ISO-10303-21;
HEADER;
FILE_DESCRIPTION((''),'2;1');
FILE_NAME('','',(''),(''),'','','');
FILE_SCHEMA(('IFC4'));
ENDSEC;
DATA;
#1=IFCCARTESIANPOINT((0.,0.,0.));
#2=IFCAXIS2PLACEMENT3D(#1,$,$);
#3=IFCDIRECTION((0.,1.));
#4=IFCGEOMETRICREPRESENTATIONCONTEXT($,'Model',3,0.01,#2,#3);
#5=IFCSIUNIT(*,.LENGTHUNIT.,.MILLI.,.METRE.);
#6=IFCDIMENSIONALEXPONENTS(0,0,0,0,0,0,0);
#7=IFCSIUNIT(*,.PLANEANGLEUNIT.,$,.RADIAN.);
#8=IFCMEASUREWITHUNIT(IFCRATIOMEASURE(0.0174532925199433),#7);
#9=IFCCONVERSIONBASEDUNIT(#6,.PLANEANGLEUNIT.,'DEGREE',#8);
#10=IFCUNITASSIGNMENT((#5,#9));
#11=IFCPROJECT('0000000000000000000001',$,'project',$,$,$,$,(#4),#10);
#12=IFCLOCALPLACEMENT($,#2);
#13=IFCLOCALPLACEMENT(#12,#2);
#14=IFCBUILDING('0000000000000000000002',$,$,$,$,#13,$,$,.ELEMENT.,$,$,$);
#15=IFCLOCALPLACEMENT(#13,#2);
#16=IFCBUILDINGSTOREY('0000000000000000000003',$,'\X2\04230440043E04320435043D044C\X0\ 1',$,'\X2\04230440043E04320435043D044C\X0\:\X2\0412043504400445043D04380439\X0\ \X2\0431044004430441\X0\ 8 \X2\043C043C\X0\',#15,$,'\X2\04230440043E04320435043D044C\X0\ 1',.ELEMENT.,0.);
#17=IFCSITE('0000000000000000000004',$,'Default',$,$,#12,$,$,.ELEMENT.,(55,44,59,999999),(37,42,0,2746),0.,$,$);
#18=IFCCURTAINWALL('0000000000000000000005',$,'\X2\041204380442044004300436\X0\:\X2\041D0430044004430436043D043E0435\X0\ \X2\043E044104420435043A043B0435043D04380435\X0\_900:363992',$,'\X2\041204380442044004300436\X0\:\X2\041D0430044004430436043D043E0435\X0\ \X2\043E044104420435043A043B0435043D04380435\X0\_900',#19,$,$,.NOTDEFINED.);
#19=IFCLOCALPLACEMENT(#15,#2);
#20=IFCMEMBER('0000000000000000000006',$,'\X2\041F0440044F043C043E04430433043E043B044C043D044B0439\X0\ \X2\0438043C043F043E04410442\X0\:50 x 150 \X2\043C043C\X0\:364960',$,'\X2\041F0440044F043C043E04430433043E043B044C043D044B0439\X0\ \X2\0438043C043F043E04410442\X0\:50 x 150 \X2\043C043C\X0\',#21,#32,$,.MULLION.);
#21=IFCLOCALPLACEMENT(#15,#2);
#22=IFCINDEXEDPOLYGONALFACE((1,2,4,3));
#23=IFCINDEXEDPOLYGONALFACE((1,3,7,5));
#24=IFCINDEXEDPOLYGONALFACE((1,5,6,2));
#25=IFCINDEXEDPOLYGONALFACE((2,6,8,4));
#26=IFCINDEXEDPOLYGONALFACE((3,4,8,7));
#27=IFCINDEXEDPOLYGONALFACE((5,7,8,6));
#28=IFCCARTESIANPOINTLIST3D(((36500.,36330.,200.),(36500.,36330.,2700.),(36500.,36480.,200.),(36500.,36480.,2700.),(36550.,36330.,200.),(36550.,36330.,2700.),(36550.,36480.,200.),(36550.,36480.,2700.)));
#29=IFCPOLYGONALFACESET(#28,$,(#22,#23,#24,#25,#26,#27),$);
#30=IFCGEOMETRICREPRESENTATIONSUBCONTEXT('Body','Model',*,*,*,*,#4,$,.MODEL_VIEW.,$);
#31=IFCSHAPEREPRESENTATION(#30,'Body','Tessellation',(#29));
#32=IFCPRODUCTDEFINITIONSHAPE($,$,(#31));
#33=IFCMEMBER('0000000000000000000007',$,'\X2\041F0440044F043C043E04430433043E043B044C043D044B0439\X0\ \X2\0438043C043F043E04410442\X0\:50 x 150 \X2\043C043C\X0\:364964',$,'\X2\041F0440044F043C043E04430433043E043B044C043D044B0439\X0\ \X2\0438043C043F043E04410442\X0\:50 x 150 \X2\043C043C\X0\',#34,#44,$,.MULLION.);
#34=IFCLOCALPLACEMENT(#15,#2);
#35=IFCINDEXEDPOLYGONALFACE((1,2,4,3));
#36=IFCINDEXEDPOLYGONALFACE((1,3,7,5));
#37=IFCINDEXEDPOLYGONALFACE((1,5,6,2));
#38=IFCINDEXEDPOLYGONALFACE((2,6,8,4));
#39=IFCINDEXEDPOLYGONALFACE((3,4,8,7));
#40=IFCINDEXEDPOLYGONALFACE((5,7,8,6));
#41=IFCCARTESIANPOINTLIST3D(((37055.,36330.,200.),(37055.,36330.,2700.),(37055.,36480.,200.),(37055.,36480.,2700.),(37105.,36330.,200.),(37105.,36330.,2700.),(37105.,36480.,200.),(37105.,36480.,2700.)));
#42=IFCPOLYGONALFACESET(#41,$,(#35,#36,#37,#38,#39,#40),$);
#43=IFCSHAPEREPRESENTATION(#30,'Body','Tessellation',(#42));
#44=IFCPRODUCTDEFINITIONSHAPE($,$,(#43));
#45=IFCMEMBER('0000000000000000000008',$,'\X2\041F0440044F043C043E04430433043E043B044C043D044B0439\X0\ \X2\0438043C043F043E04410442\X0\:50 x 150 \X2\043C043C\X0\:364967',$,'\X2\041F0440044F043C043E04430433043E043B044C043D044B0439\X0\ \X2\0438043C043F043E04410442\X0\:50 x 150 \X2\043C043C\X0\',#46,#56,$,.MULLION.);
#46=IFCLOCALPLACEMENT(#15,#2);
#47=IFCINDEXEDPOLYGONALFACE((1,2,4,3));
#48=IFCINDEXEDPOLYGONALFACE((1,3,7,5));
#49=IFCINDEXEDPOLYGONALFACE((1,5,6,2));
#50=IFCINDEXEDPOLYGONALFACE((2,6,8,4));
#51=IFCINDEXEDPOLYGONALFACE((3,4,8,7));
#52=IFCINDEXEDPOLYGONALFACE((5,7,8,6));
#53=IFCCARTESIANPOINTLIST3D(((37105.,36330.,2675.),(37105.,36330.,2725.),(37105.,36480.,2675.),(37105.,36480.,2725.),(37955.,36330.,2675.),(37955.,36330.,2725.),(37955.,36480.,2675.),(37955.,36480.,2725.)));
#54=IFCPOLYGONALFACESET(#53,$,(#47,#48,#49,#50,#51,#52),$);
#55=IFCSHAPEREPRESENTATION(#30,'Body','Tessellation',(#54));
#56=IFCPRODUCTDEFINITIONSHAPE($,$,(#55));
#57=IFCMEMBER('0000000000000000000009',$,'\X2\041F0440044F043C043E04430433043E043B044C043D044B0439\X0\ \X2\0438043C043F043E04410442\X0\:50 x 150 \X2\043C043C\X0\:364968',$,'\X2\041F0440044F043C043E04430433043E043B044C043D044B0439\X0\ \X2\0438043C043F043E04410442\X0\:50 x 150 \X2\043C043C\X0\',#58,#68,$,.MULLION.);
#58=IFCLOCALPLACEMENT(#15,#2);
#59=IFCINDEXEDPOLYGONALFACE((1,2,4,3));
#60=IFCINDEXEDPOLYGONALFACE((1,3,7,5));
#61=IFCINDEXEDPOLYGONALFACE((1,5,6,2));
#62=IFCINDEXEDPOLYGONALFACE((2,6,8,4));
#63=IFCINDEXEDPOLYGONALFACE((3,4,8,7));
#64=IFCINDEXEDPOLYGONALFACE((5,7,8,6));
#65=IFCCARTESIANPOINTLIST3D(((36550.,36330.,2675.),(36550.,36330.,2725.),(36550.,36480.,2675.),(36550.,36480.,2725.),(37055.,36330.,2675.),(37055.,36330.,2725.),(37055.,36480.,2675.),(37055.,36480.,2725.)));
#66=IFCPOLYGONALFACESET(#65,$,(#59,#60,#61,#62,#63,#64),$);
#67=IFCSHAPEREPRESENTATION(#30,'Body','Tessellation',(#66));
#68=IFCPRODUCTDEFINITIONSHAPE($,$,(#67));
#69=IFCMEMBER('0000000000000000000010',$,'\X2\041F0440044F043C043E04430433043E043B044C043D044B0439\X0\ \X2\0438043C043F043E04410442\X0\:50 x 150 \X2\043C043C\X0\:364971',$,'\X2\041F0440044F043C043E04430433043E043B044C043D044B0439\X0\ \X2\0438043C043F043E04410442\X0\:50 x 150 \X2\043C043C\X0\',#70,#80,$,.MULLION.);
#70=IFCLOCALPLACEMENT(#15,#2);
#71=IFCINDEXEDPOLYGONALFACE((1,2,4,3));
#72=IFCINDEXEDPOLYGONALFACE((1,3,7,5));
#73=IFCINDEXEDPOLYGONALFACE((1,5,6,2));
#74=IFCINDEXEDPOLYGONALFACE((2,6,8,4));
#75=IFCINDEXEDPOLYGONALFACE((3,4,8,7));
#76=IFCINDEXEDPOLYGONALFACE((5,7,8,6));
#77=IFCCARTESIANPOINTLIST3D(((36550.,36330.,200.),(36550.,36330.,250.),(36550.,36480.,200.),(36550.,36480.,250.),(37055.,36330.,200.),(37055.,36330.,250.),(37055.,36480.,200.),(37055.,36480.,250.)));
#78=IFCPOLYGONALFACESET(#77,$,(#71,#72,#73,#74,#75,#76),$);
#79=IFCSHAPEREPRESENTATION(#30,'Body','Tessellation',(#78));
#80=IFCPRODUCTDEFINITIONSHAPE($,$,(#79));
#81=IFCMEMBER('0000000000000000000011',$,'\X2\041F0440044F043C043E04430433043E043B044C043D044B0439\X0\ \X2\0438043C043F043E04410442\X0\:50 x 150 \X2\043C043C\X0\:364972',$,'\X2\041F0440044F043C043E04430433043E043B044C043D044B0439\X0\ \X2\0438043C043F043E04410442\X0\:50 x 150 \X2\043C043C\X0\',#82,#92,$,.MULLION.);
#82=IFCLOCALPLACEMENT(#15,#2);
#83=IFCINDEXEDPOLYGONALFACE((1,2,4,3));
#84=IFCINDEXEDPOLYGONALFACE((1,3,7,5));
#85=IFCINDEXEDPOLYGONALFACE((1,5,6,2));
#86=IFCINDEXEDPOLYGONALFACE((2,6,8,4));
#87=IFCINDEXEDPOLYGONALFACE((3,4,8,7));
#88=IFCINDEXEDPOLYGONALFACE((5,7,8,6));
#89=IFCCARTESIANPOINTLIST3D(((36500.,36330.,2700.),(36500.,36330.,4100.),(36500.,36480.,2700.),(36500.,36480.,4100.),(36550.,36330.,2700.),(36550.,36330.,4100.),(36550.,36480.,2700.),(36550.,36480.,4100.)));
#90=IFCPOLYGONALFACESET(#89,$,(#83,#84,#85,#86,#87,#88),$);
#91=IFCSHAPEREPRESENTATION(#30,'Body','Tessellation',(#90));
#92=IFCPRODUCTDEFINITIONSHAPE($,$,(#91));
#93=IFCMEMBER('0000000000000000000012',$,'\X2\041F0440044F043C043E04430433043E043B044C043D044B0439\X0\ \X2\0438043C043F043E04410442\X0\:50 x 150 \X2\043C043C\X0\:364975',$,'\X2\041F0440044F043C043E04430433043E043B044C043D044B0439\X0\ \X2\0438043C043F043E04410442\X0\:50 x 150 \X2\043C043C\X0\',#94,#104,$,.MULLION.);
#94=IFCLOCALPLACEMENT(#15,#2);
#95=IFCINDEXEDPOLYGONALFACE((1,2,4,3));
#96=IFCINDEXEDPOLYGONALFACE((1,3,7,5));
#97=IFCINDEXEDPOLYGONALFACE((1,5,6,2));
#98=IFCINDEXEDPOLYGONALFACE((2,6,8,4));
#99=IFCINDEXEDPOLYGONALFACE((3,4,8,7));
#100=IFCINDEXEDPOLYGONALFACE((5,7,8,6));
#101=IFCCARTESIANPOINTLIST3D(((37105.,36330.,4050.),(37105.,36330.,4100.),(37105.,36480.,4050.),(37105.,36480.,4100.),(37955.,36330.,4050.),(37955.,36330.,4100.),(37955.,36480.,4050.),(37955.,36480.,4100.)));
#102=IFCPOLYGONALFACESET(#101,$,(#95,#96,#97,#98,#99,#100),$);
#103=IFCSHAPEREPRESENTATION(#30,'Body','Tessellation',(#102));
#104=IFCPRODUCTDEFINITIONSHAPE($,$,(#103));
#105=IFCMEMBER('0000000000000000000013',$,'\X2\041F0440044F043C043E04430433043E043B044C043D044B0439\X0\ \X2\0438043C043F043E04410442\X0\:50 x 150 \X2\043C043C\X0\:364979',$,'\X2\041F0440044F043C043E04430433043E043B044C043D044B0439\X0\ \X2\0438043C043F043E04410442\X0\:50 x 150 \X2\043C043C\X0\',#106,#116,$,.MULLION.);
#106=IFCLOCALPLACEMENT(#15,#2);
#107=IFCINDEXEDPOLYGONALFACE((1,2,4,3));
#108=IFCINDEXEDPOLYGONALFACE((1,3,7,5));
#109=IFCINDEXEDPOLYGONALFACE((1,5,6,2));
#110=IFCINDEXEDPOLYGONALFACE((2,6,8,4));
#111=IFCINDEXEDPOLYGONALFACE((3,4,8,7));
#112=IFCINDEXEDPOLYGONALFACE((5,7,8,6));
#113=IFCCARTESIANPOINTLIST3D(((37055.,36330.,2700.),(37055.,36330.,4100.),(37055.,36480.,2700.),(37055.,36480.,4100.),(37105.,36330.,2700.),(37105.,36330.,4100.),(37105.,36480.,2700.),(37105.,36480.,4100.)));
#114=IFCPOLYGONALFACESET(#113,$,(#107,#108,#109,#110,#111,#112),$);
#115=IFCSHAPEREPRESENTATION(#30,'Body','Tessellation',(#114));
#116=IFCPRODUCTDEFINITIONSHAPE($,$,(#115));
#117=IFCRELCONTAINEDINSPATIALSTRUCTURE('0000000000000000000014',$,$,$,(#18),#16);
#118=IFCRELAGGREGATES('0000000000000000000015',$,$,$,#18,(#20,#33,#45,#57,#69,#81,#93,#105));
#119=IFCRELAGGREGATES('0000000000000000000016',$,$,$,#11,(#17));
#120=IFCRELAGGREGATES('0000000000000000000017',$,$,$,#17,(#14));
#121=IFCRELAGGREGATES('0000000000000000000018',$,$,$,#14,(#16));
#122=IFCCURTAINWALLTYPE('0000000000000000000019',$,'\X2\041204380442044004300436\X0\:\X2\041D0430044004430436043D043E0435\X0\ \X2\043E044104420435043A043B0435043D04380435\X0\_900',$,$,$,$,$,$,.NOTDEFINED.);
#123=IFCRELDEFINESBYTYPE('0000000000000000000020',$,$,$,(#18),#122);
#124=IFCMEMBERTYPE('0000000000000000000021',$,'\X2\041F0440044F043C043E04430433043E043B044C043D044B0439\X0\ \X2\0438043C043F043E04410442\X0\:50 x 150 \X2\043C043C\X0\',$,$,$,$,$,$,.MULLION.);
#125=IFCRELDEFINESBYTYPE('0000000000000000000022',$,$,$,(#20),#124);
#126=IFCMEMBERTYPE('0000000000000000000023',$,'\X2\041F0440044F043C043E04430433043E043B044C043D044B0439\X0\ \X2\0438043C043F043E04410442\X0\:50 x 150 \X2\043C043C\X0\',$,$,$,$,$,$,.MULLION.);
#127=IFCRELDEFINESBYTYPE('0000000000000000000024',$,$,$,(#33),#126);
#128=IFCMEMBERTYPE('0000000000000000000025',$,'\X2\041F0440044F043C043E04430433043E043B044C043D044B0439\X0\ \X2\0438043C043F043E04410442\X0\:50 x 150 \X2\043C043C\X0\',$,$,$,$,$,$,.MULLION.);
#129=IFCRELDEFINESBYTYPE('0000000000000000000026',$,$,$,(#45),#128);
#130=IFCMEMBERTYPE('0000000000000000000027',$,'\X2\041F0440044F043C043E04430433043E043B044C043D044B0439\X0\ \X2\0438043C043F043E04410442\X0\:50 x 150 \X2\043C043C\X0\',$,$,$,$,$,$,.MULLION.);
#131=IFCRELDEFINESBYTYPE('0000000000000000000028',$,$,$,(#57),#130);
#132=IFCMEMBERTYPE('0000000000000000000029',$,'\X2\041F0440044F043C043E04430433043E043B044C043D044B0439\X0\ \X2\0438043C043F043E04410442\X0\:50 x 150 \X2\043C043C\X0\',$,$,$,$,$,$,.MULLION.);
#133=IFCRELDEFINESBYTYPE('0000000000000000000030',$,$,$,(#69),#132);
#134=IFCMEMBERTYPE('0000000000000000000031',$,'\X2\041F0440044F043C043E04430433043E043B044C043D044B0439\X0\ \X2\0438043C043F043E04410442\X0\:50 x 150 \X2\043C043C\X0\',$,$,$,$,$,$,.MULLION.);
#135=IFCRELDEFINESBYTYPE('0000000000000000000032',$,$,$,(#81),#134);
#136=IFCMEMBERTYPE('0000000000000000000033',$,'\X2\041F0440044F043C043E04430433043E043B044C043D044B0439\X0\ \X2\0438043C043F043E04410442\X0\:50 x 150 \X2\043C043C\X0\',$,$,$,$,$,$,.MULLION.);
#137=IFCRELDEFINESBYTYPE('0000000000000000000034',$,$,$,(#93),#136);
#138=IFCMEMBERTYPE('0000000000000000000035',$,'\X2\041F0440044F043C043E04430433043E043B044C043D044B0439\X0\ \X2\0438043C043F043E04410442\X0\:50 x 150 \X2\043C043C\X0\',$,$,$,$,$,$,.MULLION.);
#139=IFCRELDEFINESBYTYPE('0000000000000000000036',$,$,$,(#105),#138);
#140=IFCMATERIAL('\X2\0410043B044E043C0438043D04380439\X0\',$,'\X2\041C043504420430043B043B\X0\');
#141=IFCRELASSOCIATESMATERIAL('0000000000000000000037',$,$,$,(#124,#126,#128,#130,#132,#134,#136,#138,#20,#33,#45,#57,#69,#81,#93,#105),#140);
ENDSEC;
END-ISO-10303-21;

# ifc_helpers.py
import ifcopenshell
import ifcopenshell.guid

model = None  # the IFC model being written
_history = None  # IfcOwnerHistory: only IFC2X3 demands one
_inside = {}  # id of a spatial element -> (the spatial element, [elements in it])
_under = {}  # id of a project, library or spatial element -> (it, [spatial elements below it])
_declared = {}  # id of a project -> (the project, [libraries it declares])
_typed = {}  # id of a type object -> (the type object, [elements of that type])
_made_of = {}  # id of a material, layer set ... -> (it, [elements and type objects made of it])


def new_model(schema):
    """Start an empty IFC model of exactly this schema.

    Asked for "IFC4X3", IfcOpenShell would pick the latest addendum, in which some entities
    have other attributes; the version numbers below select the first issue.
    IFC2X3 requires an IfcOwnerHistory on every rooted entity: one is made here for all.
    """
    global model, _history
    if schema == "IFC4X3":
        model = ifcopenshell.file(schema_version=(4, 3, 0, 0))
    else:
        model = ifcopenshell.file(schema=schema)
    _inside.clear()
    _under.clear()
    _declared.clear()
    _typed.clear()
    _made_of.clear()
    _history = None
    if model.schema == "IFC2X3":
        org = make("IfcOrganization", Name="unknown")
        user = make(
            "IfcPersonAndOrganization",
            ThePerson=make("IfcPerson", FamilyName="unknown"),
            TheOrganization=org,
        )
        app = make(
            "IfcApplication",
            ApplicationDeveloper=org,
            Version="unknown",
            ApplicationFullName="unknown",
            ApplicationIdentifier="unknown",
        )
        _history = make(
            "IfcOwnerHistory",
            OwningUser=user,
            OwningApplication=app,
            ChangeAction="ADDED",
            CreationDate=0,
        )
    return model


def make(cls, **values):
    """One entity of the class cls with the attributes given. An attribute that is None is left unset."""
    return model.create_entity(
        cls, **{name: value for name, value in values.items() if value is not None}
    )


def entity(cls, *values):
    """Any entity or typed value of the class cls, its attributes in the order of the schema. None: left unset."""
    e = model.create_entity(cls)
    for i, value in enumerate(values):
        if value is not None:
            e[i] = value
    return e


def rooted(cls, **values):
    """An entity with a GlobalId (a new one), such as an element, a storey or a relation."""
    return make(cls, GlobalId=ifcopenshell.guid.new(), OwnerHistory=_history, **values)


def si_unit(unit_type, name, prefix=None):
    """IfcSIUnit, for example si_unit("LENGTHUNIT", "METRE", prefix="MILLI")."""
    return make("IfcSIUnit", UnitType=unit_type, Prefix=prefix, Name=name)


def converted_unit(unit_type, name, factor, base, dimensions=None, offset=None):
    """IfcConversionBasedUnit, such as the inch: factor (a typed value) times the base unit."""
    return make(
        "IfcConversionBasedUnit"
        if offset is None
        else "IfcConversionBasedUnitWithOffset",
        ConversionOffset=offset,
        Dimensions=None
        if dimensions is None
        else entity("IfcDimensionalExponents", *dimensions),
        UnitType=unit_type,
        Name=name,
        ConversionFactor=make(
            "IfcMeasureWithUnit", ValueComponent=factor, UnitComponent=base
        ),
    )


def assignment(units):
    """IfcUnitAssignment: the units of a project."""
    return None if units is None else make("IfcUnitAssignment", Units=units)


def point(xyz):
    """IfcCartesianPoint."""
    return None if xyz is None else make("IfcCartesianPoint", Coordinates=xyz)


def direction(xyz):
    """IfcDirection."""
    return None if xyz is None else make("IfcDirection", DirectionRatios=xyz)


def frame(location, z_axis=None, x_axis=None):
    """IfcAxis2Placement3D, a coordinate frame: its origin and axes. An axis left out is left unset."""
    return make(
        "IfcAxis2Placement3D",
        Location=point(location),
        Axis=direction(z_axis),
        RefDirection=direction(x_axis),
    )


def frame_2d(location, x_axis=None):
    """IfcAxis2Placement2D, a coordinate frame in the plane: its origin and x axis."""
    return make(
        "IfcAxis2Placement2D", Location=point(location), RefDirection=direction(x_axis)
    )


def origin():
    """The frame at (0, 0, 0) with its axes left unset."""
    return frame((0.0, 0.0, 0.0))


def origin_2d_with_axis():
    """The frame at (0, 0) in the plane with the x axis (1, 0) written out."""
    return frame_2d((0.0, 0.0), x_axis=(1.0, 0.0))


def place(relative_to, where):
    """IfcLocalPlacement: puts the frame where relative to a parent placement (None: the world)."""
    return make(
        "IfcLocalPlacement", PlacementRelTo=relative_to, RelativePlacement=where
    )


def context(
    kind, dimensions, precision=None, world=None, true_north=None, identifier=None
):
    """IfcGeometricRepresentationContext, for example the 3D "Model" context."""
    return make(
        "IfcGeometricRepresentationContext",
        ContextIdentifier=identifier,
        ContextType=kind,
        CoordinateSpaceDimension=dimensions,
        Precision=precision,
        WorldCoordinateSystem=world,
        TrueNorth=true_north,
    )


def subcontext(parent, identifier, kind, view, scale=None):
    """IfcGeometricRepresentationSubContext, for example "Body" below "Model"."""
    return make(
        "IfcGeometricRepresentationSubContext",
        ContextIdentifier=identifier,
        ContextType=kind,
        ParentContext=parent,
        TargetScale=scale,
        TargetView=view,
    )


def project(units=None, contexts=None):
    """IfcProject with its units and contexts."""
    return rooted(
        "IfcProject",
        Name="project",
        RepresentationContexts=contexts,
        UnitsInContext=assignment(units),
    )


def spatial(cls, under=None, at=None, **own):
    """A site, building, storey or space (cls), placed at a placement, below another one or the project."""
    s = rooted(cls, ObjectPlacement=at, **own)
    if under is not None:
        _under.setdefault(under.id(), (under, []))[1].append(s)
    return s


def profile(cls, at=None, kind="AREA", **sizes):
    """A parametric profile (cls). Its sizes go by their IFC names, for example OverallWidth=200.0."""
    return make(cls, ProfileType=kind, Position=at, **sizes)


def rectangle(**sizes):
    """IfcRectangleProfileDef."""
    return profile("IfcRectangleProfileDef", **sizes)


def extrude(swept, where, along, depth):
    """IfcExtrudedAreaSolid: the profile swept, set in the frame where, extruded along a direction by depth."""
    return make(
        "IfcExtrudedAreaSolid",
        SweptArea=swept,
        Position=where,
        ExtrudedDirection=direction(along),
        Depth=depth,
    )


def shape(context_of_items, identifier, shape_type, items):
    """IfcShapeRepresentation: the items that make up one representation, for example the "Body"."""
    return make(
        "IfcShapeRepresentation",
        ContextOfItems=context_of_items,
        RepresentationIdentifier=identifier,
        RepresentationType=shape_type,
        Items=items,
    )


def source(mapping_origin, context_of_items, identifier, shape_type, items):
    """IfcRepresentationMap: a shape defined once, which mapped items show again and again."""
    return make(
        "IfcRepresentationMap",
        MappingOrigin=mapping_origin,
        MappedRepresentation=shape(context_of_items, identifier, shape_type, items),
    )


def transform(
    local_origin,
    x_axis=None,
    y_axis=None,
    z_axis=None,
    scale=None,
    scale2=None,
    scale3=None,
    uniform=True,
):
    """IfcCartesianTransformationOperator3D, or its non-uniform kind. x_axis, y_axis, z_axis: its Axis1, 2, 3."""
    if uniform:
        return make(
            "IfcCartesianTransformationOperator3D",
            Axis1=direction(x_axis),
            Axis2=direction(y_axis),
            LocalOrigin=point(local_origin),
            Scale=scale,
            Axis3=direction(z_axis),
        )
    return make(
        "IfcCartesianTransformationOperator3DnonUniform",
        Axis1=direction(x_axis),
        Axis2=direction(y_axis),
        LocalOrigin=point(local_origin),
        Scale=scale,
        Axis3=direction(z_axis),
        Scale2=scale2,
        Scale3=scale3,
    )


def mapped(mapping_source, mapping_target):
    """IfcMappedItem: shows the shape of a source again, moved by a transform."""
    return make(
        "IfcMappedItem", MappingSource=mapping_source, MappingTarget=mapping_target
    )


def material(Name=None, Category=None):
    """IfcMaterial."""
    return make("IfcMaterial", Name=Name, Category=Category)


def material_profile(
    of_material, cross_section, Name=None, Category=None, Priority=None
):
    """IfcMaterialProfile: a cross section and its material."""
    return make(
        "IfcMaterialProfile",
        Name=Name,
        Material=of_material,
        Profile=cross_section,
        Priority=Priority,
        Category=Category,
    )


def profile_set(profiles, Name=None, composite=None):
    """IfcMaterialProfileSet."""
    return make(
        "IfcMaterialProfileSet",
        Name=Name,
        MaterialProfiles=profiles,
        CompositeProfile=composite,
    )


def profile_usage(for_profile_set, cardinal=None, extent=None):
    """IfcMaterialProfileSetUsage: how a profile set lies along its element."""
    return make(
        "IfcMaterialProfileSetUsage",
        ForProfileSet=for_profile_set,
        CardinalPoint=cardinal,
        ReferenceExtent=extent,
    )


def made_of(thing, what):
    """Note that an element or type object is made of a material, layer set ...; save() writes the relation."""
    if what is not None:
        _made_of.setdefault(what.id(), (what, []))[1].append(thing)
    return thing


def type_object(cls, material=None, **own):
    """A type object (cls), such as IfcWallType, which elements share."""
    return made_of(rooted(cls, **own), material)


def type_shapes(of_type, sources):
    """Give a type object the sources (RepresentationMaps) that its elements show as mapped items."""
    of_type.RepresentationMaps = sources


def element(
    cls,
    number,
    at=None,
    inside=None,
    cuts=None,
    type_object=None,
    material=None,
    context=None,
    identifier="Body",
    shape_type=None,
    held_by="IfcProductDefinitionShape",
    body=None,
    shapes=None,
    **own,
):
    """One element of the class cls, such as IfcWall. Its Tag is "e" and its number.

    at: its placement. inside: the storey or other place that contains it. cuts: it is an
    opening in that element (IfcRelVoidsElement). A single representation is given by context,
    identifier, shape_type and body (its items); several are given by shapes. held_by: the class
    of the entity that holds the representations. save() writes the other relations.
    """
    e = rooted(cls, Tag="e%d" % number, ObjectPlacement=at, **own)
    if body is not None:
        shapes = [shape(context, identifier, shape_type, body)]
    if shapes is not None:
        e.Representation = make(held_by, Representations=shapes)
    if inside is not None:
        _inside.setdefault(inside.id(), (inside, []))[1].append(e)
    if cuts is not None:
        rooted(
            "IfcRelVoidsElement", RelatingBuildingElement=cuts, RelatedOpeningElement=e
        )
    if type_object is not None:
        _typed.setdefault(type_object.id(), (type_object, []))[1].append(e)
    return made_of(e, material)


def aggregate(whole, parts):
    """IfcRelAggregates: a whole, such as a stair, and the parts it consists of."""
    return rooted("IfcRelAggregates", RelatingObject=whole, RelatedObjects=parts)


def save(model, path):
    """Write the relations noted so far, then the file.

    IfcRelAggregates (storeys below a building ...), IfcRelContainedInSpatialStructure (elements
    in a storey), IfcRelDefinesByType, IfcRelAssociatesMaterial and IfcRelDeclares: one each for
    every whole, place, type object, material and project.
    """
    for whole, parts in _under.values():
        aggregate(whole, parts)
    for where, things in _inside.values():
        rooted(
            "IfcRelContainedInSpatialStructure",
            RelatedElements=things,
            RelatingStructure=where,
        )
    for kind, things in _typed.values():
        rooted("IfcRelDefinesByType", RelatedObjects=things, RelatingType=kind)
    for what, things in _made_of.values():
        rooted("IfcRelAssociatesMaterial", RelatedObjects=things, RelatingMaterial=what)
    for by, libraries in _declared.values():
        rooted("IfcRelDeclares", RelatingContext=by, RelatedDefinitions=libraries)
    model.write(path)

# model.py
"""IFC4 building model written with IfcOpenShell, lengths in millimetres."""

from ifc_helpers import new_model, entity, si_unit, converted_unit, direction, frame, origin, origin_2d_with_axis, place, context, subcontext, project, spatial, rectangle, extrude, source, transform, mapped, material, material_profile, profile_set, profile_usage, type_object, type_shapes, element, aggregate, save


model = new_model("IFC4")

# Units and contexts
model_context = context("Model", 3, precision=0.01, world=origin(), true_north=direction((0.0, 1.0)))
body_context = subcontext(model_context, "Body", "Model", "MODEL_VIEW")
ifc_project = project(units=[si_unit("LENGTHUNIT", "METRE", prefix="MILLI"), converted_unit("PLANEANGLEUNIT", "DEGREE", entity("IfcRatioMeasure", 0.0174532925199433), si_unit("PLANEANGLEUNIT", "RADIAN"), dimensions=[0, 0, 0, 0, 0, 0, 0])], contexts=[model_context])

# Site, building, storey
site_placement = place(None, origin())
site = spatial("IfcSite", under=ifc_project, at=site_placement, Name="Default", CompositionType="ELEMENT", RefLatitude=(55, 44, 59, 999999), RefLongitude=(37, 42, 0, 2746), RefElevation=0.0)
building_placement = place(site_placement, origin())
building = spatial("IfcBuilding", under=site, at=building_placement, CompositionType="ELEMENT")
storey_placement = place(building_placement, origin())
storey = spatial("IfcBuildingStorey", under=building, at=storey_placement, Name="Уровень 1", ObjectType="Уровень:Верхний брус 8 мм", LongName="Уровень 1", CompositionType="ELEMENT", Elevation=0.0)

# Curtain wall, members
ifc_material_1 = material(Name="Алюминий", Category="Металл")
ifc_material_profile = material_profile(ifc_material_1, rectangle(XDim=150.0, YDim=50.0, at=origin_2d_with_axis()), Name="50 x 150 мм")
ifc_profile_set = profile_set([ifc_material_profile], Name="50 x 150 мм")
curtain_wall_type_1 = type_object("IfcCurtainWallType", Name="Витраж:Наружное остекление_900", PredefinedType="NOTDEFINED")
curtain_wall_1_placement = place(storey_placement, origin())
curtain_wall_1 = element("IfcCurtainWall", 1, at=curtain_wall_1_placement, inside=storey, type_object=curtain_wall_type_1, Name="Витраж:Наружное остекление_900:363992", ObjectType="Витраж:Наружное остекление_900", PredefinedType="NOTDEFINED")
ifc_profile_usage_1 = profile_usage(ifc_profile_set)
member_type_1 = type_object("IfcMemberType", Name="Прямоугольный импост:50 x 150 мм", PredefinedType="MULLION", material=ifc_profile_set)
shared_shape_1 = source(origin(), body_context, "Body", "SweptSolid", [
    extrude(rectangle(XDim=150.0, YDim=50.0, at=origin_2d_with_axis()), frame((-25.0, 0.0, -2500.0), z_axis=(0.0, 0.0, 1.0), x_axis=(0.0, -1.0, 0.0)), (0.0, 0.0, 1.0), 2500.0),
])
type_shapes(member_type_1, [shared_shape_1])
member_1_placement = place(storey_placement, frame((36500.0, 36405.0, 200.0), z_axis=(0.0, 0.0, -1.0), x_axis=(-1.0, 0.0, 0.0)))
member_1 = element("IfcMember", 2, at=member_1_placement, type_object=member_type_1, material=ifc_profile_usage_1, Name="Прямоугольный импост:50 x 150 мм:364960", ObjectType="Прямоугольный импост:50 x 150 мм", PredefinedType="MULLION", context=body_context, shape_type="MappedRepresentation", body=[
    mapped(shared_shape_1, transform((0.0, 0.0, 0.0), scale=1.0)),
])
ifc_profile_usage_2 = profile_usage(ifc_profile_set)
member_type_2 = type_object("IfcMemberType", Name="Прямоугольный импост:50 x 150 мм", PredefinedType="MULLION", material=ifc_profile_set)
shared_shape_2 = source(origin(), body_context, "Body", "SweptSolid", [
    extrude(rectangle(XDim=150.0, YDim=50.0, at=origin_2d_with_axis()), frame((0.0, 0.0, -2500.0), z_axis=(0.0, 0.0, 1.0), x_axis=(0.0, -1.0, 0.0)), (0.0, 0.0, 1.0), 2500.0),
])
type_shapes(member_type_2, [shared_shape_2])
member_2_placement = place(storey_placement, frame((37080.0, 36405.0, 200.0), z_axis=(0.0, 0.0, -1.0), x_axis=(-1.0, 0.0, 0.0)))
member_2 = element("IfcMember", 3, at=member_2_placement, type_object=member_type_2, material=ifc_profile_usage_2, Name="Прямоугольный импост:50 x 150 мм:364964", ObjectType="Прямоугольный импост:50 x 150 мм", PredefinedType="MULLION", context=body_context, shape_type="MappedRepresentation", body=[
    mapped(shared_shape_2, transform((0.0, 0.0, 0.0), scale=1.0)),
])
ifc_profile_usage_3 = profile_usage(ifc_profile_set)
member_type_3 = type_object("IfcMemberType", Name="Прямоугольный импост:50 x 150 мм", PredefinedType="MULLION", material=ifc_profile_set)
shared_shape_3 = source(origin(), body_context, "Body", "SweptSolid", [
    extrude(rectangle(XDim=150.0, YDim=50.0, at=origin_2d_with_axis()), frame((0.0, 0.0, -850.0), z_axis=(0.0, 0.0, 1.0), x_axis=(0.0, -1.0, 0.0)), (0.0, 0.0, 1.0), 850.0),
])
type_shapes(member_type_3, [shared_shape_3])
member_3_placement = place(storey_placement, frame((37105.0, 36405.0, 2700.0), z_axis=(-1.0, 0.0, 0.0), x_axis=(0.0, 0.0, 1.0)))
member_3 = element("IfcMember", 4, at=member_3_placement, type_object=member_type_3, material=ifc_profile_usage_3, Name="Прямоугольный импост:50 x 150 мм:364967", ObjectType="Прямоугольный импост:50 x 150 мм", PredefinedType="MULLION", context=body_context, shape_type="MappedRepresentation", body=[
    mapped(shared_shape_3, transform((0.0, 0.0, 0.0), scale=1.0)),
])
ifc_profile_usage_4 = profile_usage(ifc_profile_set)
member_type_4 = type_object("IfcMemberType", Name="Прямоугольный импост:50 x 150 мм", PredefinedType="MULLION", material=ifc_profile_set)
shared_shape_4 = source(origin(), body_context, "Body", "SweptSolid", [
    extrude(rectangle(XDim=150.0, YDim=50.0, at=origin_2d_with_axis()), frame((0.0, 0.0, -505.0), z_axis=(0.0, 0.0, 1.0), x_axis=(0.0, -1.0, 0.0)), (0.0, 0.0, 1.0), 505.0),
])
type_shapes(member_type_4, [shared_shape_4])
member_4_placement = place(storey_placement, frame((36550.0, 36405.0, 2700.0), z_axis=(-1.0, 0.0, 0.0), x_axis=(0.0, 0.0, 1.0)))
member_4 = element("IfcMember", 5, at=member_4_placement, type_object=member_type_4, material=ifc_profile_usage_4, Name="Прямоугольный импост:50 x 150 мм:364968", ObjectType="Прямоугольный импост:50 x 150 мм", PredefinedType="MULLION", context=body_context, shape_type="MappedRepresentation", body=[
    mapped(shared_shape_4, transform((0.0, 0.0, 0.0), scale=1.0)),
])
ifc_profile_usage_5 = profile_usage(ifc_profile_set)
member_type_5 = type_object("IfcMemberType", Name="Прямоугольный импост:50 x 150 мм", PredefinedType="MULLION", material=ifc_profile_set)
shared_shape_5 = source(origin(), body_context, "Body", "SweptSolid", [
    extrude(rectangle(XDim=150.0, YDim=50.0, at=origin_2d_with_axis()), frame((-25.0, 0.0, -505.0), z_axis=(0.0, 0.0, 1.0), x_axis=(0.0, -1.0, 0.0)), (0.0, 0.0, 1.0), 505.0),
])
type_shapes(member_type_5, [shared_shape_5])
member_5_placement = place(storey_placement, frame((37055.0, 36405.0, 200.0), z_axis=(1.0, 0.0, 0.0), x_axis=(0.0, 0.0, -1.0)))
member_5 = element("IfcMember", 6, at=member_5_placement, type_object=member_type_5, material=ifc_profile_usage_5, Name="Прямоугольный импост:50 x 150 мм:364971", ObjectType="Прямоугольный импост:50 x 150 мм", PredefinedType="MULLION", context=body_context, shape_type="MappedRepresentation", body=[
    mapped(shared_shape_5, transform((0.0, 0.0, 0.0), scale=1.0)),
])
ifc_profile_usage_6 = profile_usage(ifc_profile_set)
member_type_6 = type_object("IfcMemberType", Name="Прямоугольный импост:50 x 150 мм", PredefinedType="MULLION", material=ifc_profile_set)
shared_shape_6 = source(origin(), body_context, "Body", "SweptSolid", [
    extrude(rectangle(XDim=150.0, YDim=50.0, at=origin_2d_with_axis()), frame((-25.0, 0.0, -1400.0), z_axis=(0.0, 0.0, 1.0), x_axis=(0.0, -1.0, 0.0)), (0.0, 0.0, 1.0), 1400.0),
])
type_shapes(member_type_6, [shared_shape_6])
member_6_placement = place(storey_placement, frame((36500.0, 36405.0, 2700.0), z_axis=(0.0, 0.0, -1.0), x_axis=(-1.0, 0.0, 0.0)))
member_6 = element("IfcMember", 7, at=member_6_placement, type_object=member_type_6, material=ifc_profile_usage_6, Name="Прямоугольный импост:50 x 150 мм:364972", ObjectType="Прямоугольный импост:50 x 150 мм", PredefinedType="MULLION", context=body_context, shape_type="MappedRepresentation", body=[
    mapped(shared_shape_6, transform((0.0, 0.0, 0.0), scale=1.0)),
])
ifc_profile_usage_7 = profile_usage(ifc_profile_set)
member_type_7 = type_object("IfcMemberType", Name="Прямоугольный импост:50 x 150 мм", PredefinedType="MULLION", material=ifc_profile_set)
shared_shape_7 = source(origin(), body_context, "Body", "SweptSolid", [
    extrude(rectangle(XDim=150.0, YDim=50.0, at=origin_2d_with_axis()), frame((-25.0, 0.0, -850.0), z_axis=(0.0, 0.0, 1.0), x_axis=(0.0, -1.0, 0.0)), (0.0, 0.0, 1.0), 850.0),
])
type_shapes(member_type_7, [shared_shape_7])
member_7_placement = place(storey_placement, frame((37105.0, 36405.0, 4100.0), z_axis=(-1.0, 0.0, 0.0), x_axis=(0.0, 0.0, 1.0)))
member_7 = element("IfcMember", 8, at=member_7_placement, type_object=member_type_7, material=ifc_profile_usage_7, Name="Прямоугольный импост:50 x 150 мм:364975", ObjectType="Прямоугольный импост:50 x 150 мм", PredefinedType="MULLION", context=body_context, shape_type="MappedRepresentation", body=[
    mapped(shared_shape_7, transform((0.0, 0.0, 0.0), scale=1.0)),
])
ifc_profile_usage_8 = profile_usage(ifc_profile_set)
member_type_8 = type_object("IfcMemberType", Name="Прямоугольный импост:50 x 150 мм", PredefinedType="MULLION", material=ifc_profile_set)
shared_shape_8 = source(origin(), body_context, "Body", "SweptSolid", [
    extrude(rectangle(XDim=150.0, YDim=50.0, at=origin_2d_with_axis()), frame((0.0, 0.0, -1400.0), z_axis=(0.0, 0.0, 1.0), x_axis=(0.0, -1.0, 0.0)), (0.0, 0.0, 1.0), 1400.0),
])
type_shapes(member_type_8, [shared_shape_8])
member_8_placement = place(storey_placement, frame((37080.0, 36405.0, 2700.0), z_axis=(0.0, 0.0, -1.0), x_axis=(-1.0, 0.0, 0.0)))
member_8 = element("IfcMember", 9, at=member_8_placement, type_object=member_type_8, material=ifc_profile_usage_8, Name="Прямоугольный импост:50 x 150 мм:364979", ObjectType="Прямоугольный импост:50 x 150 мм", PredefinedType="MULLION", context=body_context, shape_type="MappedRepresentation", body=[
    mapped(shared_shape_8, transform((0.0, 0.0, 0.0), scale=1.0)),
])
aggregate(curtain_wall_1, [member_1, member_2, member_3, member_4, member_5, member_6, member_7, member_8])

save(model, "model.ifc")
